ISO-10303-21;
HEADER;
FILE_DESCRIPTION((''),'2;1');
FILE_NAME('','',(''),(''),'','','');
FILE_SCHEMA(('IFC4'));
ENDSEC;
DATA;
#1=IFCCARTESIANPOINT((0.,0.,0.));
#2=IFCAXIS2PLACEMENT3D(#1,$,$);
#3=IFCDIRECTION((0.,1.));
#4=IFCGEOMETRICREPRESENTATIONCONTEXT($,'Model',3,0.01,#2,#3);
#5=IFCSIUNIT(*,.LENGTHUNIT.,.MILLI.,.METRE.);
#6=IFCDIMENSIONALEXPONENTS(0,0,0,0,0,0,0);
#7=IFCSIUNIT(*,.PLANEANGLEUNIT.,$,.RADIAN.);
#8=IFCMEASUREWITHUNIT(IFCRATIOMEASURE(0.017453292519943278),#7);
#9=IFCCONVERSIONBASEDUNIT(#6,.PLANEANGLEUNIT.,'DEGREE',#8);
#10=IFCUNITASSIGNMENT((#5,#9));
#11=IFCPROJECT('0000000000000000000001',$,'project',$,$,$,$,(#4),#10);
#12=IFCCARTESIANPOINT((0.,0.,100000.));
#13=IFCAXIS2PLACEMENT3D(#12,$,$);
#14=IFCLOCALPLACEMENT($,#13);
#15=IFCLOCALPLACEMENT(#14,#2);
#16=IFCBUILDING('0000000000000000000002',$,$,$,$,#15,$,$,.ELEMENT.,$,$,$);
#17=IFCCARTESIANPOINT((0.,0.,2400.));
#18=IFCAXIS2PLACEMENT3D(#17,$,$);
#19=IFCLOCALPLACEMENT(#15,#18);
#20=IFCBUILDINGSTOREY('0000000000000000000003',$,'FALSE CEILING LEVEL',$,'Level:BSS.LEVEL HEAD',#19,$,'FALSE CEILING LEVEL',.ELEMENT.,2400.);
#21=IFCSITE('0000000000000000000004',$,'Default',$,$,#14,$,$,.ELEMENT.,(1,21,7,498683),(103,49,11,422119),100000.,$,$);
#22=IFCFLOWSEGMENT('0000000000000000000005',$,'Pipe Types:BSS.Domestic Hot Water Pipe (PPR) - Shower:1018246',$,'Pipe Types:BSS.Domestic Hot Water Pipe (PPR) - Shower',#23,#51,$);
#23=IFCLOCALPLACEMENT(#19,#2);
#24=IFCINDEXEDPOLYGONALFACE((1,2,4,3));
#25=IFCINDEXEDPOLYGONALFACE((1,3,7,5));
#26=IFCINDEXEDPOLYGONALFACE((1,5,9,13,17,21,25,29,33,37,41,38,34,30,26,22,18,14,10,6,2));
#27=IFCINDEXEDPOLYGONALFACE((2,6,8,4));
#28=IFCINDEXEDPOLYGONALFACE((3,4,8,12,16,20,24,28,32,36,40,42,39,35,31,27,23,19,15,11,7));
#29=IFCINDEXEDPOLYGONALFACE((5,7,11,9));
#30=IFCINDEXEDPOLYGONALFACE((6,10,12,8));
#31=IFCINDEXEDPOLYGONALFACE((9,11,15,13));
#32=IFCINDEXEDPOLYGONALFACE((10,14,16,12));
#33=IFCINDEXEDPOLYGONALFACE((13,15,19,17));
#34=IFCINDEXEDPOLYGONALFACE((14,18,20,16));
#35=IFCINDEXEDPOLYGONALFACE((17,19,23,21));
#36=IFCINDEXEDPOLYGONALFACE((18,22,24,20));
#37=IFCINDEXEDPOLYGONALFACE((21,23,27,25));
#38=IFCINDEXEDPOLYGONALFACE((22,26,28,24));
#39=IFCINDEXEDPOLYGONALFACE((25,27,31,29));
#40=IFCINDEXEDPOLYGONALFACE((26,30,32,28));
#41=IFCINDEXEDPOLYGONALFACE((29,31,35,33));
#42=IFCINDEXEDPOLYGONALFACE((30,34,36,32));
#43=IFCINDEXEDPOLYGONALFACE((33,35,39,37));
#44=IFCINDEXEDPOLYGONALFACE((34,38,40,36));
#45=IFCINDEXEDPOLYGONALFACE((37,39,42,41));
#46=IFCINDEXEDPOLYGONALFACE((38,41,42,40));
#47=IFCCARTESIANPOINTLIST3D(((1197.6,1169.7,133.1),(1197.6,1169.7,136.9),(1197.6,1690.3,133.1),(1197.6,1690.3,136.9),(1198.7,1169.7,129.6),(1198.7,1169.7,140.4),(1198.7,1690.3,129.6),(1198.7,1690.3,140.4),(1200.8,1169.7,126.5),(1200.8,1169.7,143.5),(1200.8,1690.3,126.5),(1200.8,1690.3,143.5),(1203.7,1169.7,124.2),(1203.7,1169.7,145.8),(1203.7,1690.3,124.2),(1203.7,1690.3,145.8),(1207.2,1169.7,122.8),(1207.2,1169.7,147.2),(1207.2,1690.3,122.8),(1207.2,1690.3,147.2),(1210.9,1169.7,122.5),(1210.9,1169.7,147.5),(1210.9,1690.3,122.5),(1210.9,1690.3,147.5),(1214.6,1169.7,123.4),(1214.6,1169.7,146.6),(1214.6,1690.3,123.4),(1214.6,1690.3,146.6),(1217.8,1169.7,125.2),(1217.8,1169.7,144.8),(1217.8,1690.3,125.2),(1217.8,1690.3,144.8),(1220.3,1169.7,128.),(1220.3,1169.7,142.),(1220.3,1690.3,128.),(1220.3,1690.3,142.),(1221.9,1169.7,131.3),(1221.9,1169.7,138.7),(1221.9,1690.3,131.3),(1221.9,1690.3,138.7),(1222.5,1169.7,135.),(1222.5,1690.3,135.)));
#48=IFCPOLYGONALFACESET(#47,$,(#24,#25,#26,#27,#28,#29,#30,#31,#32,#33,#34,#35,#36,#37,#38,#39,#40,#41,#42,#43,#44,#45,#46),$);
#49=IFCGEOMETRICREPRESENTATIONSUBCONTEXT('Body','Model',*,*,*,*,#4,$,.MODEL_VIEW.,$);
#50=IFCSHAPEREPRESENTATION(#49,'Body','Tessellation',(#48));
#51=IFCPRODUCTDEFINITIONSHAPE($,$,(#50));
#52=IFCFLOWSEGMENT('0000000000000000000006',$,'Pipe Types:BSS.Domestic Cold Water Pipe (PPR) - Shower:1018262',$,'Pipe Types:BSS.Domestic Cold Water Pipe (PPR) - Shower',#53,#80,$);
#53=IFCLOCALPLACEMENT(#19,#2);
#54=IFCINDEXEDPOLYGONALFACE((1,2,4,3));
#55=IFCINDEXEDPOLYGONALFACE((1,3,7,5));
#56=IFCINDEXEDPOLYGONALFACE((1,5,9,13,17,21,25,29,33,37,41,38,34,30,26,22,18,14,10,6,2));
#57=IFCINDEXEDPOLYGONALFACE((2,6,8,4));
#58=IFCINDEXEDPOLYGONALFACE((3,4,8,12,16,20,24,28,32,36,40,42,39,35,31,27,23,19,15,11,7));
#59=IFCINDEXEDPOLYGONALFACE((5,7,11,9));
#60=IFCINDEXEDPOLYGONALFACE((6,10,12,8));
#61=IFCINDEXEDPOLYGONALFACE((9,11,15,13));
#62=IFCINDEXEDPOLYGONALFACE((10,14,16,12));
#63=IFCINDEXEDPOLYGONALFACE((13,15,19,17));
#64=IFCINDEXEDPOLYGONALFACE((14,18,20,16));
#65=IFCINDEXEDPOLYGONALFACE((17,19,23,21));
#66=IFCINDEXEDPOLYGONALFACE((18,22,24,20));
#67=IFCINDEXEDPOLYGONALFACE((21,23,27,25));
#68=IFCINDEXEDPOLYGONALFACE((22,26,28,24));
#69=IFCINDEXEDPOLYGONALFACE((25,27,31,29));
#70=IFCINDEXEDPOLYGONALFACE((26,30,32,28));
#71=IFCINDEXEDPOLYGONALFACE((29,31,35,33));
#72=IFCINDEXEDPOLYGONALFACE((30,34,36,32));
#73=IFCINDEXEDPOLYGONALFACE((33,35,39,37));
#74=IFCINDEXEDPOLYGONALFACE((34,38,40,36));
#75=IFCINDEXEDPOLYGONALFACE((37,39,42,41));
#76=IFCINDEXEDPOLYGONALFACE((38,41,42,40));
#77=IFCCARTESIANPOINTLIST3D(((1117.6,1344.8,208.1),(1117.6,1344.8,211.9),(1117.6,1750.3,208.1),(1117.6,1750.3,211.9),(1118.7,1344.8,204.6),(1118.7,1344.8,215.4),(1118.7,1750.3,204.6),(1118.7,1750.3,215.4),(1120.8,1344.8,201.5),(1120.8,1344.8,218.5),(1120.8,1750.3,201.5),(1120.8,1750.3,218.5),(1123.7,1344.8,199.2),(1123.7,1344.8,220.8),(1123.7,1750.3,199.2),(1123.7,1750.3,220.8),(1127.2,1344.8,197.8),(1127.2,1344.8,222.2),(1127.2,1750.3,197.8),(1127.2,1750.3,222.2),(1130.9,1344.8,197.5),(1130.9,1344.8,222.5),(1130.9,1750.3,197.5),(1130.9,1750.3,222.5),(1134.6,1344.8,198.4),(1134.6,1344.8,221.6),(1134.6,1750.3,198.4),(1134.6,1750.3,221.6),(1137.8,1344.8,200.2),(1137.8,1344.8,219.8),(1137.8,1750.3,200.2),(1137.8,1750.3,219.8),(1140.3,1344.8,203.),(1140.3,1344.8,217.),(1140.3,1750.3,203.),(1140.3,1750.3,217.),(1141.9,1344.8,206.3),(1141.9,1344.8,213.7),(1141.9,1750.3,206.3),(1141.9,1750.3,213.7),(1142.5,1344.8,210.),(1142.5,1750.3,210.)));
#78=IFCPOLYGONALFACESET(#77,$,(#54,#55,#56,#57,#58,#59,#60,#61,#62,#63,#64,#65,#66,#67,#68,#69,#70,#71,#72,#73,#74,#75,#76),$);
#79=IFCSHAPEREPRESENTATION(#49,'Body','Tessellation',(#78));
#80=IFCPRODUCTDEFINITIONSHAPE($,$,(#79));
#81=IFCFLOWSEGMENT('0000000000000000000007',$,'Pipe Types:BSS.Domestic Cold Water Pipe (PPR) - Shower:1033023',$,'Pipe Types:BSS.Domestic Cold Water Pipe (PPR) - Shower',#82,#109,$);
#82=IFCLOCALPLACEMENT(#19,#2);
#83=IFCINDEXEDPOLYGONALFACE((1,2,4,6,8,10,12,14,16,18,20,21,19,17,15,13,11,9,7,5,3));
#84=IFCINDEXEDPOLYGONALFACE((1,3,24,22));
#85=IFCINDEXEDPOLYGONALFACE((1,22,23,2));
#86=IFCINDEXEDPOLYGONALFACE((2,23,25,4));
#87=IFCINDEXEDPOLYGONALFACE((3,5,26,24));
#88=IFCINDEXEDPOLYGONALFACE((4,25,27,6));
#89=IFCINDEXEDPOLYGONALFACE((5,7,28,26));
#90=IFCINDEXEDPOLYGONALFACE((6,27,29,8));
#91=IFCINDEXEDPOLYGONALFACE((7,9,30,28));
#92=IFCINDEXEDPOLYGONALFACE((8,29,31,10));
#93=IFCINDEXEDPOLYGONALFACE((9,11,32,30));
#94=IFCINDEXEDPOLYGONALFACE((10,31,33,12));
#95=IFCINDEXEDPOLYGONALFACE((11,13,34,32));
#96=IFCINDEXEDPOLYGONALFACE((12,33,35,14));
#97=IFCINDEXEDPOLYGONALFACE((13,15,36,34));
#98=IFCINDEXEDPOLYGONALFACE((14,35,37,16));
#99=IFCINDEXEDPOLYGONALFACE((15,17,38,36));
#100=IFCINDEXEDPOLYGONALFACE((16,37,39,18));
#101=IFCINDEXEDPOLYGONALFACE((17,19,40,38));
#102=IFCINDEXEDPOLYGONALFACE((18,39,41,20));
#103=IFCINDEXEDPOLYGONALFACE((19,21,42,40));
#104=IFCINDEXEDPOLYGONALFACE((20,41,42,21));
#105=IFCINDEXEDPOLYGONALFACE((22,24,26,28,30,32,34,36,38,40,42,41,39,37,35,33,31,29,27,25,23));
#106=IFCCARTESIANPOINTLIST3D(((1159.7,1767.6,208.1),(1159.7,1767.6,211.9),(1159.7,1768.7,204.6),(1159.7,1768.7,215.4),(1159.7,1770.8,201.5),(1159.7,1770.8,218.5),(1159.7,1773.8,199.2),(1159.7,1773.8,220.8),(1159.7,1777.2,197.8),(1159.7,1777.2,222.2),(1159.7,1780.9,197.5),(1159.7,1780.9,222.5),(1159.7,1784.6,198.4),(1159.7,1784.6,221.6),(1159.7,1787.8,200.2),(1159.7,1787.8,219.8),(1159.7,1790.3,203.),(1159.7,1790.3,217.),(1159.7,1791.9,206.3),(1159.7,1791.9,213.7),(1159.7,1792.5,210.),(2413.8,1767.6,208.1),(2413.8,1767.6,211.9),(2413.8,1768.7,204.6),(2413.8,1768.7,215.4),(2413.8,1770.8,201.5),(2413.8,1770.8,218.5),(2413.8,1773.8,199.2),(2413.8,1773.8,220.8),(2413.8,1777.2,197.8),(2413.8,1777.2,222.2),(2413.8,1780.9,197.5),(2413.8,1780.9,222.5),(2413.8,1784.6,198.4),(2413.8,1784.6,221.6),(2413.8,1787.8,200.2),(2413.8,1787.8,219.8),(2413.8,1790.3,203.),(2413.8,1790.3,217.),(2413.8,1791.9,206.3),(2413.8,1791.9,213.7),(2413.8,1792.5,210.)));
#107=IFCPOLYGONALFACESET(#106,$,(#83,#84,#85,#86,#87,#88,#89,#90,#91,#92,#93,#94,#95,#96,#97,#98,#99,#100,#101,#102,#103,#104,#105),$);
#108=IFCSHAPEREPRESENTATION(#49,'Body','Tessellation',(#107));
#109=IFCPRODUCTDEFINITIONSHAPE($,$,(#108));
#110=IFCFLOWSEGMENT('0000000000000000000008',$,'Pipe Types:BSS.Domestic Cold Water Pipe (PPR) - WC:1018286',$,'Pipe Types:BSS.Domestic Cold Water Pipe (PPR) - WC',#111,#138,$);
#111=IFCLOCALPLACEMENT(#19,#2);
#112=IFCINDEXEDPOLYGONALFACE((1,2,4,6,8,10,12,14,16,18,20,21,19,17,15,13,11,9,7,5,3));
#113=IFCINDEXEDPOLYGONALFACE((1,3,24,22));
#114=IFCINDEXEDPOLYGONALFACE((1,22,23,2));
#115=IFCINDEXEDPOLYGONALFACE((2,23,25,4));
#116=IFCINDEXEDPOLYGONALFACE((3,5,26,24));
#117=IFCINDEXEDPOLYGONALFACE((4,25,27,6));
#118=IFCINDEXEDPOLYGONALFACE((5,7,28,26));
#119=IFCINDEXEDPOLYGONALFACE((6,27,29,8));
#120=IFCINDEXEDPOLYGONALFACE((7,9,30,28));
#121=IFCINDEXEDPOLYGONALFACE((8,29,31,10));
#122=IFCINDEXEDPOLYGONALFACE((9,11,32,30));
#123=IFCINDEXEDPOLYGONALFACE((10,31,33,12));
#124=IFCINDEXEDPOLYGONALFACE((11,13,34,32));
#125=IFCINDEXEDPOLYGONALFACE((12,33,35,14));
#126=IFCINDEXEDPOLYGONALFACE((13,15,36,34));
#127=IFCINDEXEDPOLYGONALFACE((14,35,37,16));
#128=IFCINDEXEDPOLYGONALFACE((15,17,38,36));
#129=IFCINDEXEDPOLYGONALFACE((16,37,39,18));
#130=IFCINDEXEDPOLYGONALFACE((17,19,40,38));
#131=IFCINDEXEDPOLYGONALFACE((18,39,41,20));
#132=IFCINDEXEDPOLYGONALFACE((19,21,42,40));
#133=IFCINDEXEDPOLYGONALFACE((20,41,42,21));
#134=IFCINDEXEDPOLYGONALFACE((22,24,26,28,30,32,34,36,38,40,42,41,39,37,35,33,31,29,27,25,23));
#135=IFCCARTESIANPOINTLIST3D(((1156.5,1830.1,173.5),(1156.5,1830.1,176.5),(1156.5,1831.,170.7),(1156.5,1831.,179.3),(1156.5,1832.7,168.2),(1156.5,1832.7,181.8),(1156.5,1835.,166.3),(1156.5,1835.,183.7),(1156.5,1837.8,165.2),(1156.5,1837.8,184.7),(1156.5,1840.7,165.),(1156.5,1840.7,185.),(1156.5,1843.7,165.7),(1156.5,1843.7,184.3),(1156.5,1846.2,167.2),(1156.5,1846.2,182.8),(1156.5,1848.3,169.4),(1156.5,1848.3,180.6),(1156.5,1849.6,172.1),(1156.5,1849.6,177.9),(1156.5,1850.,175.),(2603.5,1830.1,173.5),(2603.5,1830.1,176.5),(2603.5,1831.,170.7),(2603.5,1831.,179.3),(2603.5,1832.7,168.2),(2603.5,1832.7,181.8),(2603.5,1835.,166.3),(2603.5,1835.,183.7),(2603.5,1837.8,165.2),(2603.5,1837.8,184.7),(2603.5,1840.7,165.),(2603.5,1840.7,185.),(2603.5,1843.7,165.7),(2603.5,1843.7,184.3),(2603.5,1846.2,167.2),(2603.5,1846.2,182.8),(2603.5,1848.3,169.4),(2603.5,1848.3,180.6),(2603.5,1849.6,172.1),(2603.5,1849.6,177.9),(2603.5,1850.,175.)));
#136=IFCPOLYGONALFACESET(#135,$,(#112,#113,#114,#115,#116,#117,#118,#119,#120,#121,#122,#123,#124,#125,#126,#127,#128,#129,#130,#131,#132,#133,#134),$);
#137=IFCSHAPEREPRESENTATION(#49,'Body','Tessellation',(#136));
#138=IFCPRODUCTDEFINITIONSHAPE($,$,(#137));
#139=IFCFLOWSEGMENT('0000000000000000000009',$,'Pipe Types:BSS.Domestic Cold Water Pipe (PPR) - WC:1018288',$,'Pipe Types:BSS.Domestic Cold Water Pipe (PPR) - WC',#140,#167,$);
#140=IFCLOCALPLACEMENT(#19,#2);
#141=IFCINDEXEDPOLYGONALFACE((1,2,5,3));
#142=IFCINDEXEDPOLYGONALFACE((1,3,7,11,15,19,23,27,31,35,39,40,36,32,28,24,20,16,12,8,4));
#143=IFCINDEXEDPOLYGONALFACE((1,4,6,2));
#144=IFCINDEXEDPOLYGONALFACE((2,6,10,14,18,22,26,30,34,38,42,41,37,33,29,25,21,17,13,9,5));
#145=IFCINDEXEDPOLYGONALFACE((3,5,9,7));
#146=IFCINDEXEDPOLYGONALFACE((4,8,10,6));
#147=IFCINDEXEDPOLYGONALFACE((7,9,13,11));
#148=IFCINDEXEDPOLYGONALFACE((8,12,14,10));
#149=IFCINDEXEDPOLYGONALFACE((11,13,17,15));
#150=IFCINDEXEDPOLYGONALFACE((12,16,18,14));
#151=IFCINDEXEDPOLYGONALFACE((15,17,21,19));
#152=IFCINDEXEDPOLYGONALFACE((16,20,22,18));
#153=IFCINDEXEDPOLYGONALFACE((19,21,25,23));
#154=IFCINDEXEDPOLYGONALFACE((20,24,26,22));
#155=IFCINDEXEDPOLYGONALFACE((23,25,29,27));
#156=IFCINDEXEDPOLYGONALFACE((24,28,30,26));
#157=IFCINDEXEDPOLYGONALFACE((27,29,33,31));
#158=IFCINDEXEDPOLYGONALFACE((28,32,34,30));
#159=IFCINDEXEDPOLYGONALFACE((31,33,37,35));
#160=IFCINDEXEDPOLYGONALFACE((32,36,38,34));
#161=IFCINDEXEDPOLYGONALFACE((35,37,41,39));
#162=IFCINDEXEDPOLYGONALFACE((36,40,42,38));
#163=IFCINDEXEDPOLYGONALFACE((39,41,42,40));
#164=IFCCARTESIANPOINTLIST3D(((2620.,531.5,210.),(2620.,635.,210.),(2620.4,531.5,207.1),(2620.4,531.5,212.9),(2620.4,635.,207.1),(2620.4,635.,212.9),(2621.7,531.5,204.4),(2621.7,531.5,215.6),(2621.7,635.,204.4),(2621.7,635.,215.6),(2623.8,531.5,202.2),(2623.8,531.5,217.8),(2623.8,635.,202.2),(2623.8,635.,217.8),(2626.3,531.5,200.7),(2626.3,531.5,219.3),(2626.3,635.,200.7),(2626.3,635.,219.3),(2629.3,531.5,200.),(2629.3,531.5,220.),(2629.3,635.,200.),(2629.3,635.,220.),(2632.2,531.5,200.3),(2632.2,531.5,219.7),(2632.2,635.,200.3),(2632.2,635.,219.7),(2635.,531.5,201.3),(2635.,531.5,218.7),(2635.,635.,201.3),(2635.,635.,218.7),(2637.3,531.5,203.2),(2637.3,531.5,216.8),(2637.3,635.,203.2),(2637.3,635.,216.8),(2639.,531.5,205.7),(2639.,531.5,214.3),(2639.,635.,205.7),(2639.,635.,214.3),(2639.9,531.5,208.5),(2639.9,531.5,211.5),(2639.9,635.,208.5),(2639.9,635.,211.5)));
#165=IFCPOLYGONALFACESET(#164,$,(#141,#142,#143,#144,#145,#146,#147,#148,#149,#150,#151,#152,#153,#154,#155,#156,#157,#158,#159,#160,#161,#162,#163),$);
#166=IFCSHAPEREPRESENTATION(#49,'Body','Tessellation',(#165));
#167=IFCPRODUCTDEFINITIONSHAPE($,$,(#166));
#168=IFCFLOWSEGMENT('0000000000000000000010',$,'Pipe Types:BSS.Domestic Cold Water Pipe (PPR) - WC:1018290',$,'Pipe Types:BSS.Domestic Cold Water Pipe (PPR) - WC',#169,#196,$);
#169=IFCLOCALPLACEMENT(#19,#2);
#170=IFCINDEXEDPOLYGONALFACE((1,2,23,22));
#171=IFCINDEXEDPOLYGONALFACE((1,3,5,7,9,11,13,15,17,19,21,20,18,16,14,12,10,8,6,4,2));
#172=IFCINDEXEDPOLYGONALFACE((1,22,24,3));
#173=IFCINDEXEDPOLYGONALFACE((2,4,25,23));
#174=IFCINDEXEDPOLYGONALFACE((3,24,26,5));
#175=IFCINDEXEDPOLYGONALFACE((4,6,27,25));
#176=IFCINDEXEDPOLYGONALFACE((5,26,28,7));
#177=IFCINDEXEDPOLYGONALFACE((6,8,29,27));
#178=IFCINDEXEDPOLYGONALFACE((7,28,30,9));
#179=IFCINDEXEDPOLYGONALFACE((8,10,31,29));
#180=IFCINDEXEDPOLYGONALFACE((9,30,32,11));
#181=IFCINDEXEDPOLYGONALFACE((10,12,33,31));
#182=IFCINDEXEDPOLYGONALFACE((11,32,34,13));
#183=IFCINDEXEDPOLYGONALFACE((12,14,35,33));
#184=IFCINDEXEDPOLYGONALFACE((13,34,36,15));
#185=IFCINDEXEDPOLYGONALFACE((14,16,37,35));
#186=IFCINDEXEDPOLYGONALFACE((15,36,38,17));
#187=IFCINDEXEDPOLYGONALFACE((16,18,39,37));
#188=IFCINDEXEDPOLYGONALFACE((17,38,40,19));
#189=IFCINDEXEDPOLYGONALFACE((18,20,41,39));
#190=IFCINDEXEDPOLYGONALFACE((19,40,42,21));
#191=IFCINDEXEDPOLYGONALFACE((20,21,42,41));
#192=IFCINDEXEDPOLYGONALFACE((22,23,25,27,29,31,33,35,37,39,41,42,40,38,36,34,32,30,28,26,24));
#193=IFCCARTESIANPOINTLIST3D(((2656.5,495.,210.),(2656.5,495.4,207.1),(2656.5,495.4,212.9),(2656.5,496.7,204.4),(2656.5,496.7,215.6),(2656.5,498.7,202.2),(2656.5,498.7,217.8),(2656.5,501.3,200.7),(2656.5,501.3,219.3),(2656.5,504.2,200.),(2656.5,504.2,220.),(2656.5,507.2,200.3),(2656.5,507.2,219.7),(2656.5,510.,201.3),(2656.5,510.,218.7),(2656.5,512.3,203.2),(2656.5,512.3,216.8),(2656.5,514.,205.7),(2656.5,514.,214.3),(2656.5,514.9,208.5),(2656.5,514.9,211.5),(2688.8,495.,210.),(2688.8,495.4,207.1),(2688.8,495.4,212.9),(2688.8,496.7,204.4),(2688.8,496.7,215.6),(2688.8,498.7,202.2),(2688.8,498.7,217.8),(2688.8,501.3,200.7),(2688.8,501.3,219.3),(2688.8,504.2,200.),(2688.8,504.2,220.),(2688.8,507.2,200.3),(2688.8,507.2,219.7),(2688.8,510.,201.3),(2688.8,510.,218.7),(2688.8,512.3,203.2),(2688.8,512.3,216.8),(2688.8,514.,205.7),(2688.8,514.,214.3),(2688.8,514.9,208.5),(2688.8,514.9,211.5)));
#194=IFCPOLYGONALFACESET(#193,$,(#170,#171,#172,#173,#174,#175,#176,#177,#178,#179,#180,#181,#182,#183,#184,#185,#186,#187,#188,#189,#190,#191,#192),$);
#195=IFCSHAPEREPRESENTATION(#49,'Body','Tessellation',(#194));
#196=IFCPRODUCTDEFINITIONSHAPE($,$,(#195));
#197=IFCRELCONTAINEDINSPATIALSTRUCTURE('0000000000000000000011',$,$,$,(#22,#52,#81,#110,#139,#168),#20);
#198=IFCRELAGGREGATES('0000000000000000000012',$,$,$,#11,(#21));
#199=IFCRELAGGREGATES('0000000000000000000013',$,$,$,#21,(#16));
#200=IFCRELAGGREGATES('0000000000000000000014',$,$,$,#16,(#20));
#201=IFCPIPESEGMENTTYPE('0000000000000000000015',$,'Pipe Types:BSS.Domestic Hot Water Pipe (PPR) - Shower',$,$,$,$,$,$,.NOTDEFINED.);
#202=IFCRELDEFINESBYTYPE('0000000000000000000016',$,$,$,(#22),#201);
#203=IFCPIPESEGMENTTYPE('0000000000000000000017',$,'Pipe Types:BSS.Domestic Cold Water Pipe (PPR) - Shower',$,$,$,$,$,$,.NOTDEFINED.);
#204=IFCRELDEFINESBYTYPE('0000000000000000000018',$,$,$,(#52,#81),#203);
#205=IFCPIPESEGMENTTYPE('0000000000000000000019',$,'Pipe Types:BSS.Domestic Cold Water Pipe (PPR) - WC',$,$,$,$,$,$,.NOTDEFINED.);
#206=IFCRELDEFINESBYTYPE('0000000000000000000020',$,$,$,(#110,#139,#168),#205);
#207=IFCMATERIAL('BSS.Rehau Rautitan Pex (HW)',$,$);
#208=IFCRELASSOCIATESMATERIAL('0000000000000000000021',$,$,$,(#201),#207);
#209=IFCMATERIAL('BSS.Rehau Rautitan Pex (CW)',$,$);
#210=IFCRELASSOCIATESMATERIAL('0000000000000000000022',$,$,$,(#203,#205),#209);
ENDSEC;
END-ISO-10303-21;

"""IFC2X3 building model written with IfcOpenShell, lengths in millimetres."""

from ifc_helpers import new_model, entity, si_unit, converted_unit, direction, frame, frame_2d, origin, origin_2d_with_axis, place, context, subcontext, project, spatial, circle, extrude, material, type_object, element, save


model = new_model("IFC2X3")

# Units and contexts
model_context = context("Model", 3, precision=0.01, world=origin(), true_north=direction((0.0, 1.0)))
body_context = subcontext(model_context, "Body", "Model", "MODEL_VIEW")
ifc_project = project(units=[si_unit("LENGTHUNIT", "METRE", prefix="MILLI"), converted_unit("PLANEANGLEUNIT", "DEGREE", entity("IfcRatioMeasure", 0.017453292519943278), si_unit("PLANEANGLEUNIT", "RADIAN"), dimensions=[0, 0, 0, 0, 0, 0, 0])], contexts=[model_context])

# Site, building, storey
site_placement = place(None, frame((0.0, 0.0, 100000.0)))
site = spatial("IfcSite", under=ifc_project, at=site_placement, Name="Default", CompositionType="ELEMENT", RefLatitude=(1, 21, 7, 498683), RefLongitude=(103, 49, 11, 422119), RefElevation=100000.0)
building_placement = place(site_placement, origin())
building = spatial("IfcBuilding", under=site, at=building_placement, CompositionType="ELEMENT")
storey_placement = place(building_placement, frame((0.0, 0.0, 2400.0)))
storey = spatial("IfcBuildingStorey", under=building, at=storey_placement, Name="FALSE CEILING LEVEL", ObjectType="Level:BSS.LEVEL HEAD", LongName="FALSE CEILING LEVEL", CompositionType="ELEMENT", Elevation=2400.0)

# Flow segments
ifc_material_1 = material(Name="BSS.Rehau Rautitan Pex (HW)")
pipe_segment_type_1 = type_object("IfcPipeSegmentType", Name="Pipe Types:BSS.Domestic Hot Water Pipe (PPR) - Shower", PredefinedType="NOTDEFINED", material=ifc_material_1)
flow_segment_1_placement = place(storey_placement, origin())
element("IfcFlowSegment", 1, at=flow_segment_1_placement, inside=storey, type_object=pipe_segment_type_1, Name="Pipe Types:BSS.Domestic Hot Water Pipe (PPR) - Shower:1018246", ObjectType="Pipe Types:BSS.Domestic Hot Water Pipe (PPR) - Shower", context=body_context, shape_type="SweptSolid", body=[
    extrude(circle(Radius=12.5, at=origin_2d_with_axis()), frame((1210.0, 1169.7, 135.0), z_axis=(0.0, 1.0, 0.0), x_axis=(1.0, 0.0, 0.0)), (0.0, 0.0, 1.0), 520.6),
])
ifc_material_2 = material(Name="BSS.Rehau Rautitan Pex (CW)")
pipe_segment_type_2 = type_object("IfcPipeSegmentType", Name="Pipe Types:BSS.Domestic Cold Water Pipe (PPR) - Shower", PredefinedType="NOTDEFINED", material=ifc_material_2)
flow_segment_2_placement = place(storey_placement, origin())
element("IfcFlowSegment", 2, at=flow_segment_2_placement, inside=storey, type_object=pipe_segment_type_2, Name="Pipe Types:BSS.Domestic Cold Water Pipe (PPR) - Shower:1018262", ObjectType="Pipe Types:BSS.Domestic Cold Water Pipe (PPR) - Shower", context=body_context, shape_type="SweptSolid", body=[
    extrude(circle(Radius=12.5, at=frame_2d((0.0, 0.0), x_axis=(1.0, 0.0))), frame((1130.0, 1344.8, 210.0), z_axis=(0.000001, 1.0, 0.0), x_axis=(1.0, -0.000001, 0.0)), (0.0, 0.0, 1.0), 405.5),
])
flow_segment_3_placement = place(storey_placement, origin())
element("IfcFlowSegment", 3, at=flow_segment_3_placement, inside=storey, type_object=pipe_segment_type_2, Name="Pipe Types:BSS.Domestic Cold Water Pipe (PPR) - Shower:1033023", ObjectType="Pipe Types:BSS.Domestic Cold Water Pipe (PPR) - Shower", context=body_context, shape_type="SweptSolid", body=[
    extrude(circle(Radius=12.5, at=frame_2d((0.0, 0.0), x_axis=(1.0, 0.0))), frame((1159.7, 1780.0, 210.0), z_axis=(1.0, 0.0, 0.0), x_axis=(0.0, 1.0, 0.0)), (0.0, 0.0, 1.0), 1254.1),
])
pipe_segment_type_3 = type_object("IfcPipeSegmentType", Name="Pipe Types:BSS.Domestic Cold Water Pipe (PPR) - WC", PredefinedType="NOTDEFINED", material=ifc_material_2)
flow_segment_4_placement = place(storey_placement, origin())
element("IfcFlowSegment", 4, at=flow_segment_4_placement, inside=storey, type_object=pipe_segment_type_3, Name="Pipe Types:BSS.Domestic Cold Water Pipe (PPR) - WC:1018286", ObjectType="Pipe Types:BSS.Domestic Cold Water Pipe (PPR) - WC", context=body_context, shape_type="SweptSolid", body=[
    extrude(circle(Radius=10.0, at=origin_2d_with_axis()), frame((1156.5, 1840.0, 175.0), z_axis=(1.0, 0.0, 0.0), x_axis=(0.0, 1.0, 0.0)), (0.0, 0.0, 1.0), 1447.0),
])
flow_segment_5_placement = place(storey_placement, origin())
element("IfcFlowSegment", 5, at=flow_segment_5_placement, inside=storey, type_object=pipe_segment_type_3, Name="Pipe Types:BSS.Domestic Cold Water Pipe (PPR) - WC:1018288", ObjectType="Pipe Types:BSS.Domestic Cold Water Pipe (PPR) - WC", context=body_context, shape_type="SweptSolid", body=[
    extrude(circle(Radius=10.0, at=frame_2d((0.0, 0.0), x_axis=(1.0, 0.0))), frame((2630.0, 531.5, 210.0), z_axis=(0.0, 1.0, 0.0), x_axis=(-1.0, 0.0, 0.0)), (0.0, 0.0, 1.0), 103.5),
])
flow_segment_6_placement = place(storey_placement, origin())
element("IfcFlowSegment", 6, at=flow_segment_6_placement, inside=storey, type_object=pipe_segment_type_3, Name="Pipe Types:BSS.Domestic Cold Water Pipe (PPR) - WC:1018290", ObjectType="Pipe Types:BSS.Domestic Cold Water Pipe (PPR) - WC", context=body_context, shape_type="SweptSolid", body=[
    extrude(circle(Radius=10.0, at=origin_2d_with_axis()), frame((2656.5, 505.0, 210.0), z_axis=(1.0, 0.0, 0.0), x_axis=(0.0, -1.0, 0.0)), (0.0, 0.0, 1.0), 32.3),
])

save(model, "model.ifc")
